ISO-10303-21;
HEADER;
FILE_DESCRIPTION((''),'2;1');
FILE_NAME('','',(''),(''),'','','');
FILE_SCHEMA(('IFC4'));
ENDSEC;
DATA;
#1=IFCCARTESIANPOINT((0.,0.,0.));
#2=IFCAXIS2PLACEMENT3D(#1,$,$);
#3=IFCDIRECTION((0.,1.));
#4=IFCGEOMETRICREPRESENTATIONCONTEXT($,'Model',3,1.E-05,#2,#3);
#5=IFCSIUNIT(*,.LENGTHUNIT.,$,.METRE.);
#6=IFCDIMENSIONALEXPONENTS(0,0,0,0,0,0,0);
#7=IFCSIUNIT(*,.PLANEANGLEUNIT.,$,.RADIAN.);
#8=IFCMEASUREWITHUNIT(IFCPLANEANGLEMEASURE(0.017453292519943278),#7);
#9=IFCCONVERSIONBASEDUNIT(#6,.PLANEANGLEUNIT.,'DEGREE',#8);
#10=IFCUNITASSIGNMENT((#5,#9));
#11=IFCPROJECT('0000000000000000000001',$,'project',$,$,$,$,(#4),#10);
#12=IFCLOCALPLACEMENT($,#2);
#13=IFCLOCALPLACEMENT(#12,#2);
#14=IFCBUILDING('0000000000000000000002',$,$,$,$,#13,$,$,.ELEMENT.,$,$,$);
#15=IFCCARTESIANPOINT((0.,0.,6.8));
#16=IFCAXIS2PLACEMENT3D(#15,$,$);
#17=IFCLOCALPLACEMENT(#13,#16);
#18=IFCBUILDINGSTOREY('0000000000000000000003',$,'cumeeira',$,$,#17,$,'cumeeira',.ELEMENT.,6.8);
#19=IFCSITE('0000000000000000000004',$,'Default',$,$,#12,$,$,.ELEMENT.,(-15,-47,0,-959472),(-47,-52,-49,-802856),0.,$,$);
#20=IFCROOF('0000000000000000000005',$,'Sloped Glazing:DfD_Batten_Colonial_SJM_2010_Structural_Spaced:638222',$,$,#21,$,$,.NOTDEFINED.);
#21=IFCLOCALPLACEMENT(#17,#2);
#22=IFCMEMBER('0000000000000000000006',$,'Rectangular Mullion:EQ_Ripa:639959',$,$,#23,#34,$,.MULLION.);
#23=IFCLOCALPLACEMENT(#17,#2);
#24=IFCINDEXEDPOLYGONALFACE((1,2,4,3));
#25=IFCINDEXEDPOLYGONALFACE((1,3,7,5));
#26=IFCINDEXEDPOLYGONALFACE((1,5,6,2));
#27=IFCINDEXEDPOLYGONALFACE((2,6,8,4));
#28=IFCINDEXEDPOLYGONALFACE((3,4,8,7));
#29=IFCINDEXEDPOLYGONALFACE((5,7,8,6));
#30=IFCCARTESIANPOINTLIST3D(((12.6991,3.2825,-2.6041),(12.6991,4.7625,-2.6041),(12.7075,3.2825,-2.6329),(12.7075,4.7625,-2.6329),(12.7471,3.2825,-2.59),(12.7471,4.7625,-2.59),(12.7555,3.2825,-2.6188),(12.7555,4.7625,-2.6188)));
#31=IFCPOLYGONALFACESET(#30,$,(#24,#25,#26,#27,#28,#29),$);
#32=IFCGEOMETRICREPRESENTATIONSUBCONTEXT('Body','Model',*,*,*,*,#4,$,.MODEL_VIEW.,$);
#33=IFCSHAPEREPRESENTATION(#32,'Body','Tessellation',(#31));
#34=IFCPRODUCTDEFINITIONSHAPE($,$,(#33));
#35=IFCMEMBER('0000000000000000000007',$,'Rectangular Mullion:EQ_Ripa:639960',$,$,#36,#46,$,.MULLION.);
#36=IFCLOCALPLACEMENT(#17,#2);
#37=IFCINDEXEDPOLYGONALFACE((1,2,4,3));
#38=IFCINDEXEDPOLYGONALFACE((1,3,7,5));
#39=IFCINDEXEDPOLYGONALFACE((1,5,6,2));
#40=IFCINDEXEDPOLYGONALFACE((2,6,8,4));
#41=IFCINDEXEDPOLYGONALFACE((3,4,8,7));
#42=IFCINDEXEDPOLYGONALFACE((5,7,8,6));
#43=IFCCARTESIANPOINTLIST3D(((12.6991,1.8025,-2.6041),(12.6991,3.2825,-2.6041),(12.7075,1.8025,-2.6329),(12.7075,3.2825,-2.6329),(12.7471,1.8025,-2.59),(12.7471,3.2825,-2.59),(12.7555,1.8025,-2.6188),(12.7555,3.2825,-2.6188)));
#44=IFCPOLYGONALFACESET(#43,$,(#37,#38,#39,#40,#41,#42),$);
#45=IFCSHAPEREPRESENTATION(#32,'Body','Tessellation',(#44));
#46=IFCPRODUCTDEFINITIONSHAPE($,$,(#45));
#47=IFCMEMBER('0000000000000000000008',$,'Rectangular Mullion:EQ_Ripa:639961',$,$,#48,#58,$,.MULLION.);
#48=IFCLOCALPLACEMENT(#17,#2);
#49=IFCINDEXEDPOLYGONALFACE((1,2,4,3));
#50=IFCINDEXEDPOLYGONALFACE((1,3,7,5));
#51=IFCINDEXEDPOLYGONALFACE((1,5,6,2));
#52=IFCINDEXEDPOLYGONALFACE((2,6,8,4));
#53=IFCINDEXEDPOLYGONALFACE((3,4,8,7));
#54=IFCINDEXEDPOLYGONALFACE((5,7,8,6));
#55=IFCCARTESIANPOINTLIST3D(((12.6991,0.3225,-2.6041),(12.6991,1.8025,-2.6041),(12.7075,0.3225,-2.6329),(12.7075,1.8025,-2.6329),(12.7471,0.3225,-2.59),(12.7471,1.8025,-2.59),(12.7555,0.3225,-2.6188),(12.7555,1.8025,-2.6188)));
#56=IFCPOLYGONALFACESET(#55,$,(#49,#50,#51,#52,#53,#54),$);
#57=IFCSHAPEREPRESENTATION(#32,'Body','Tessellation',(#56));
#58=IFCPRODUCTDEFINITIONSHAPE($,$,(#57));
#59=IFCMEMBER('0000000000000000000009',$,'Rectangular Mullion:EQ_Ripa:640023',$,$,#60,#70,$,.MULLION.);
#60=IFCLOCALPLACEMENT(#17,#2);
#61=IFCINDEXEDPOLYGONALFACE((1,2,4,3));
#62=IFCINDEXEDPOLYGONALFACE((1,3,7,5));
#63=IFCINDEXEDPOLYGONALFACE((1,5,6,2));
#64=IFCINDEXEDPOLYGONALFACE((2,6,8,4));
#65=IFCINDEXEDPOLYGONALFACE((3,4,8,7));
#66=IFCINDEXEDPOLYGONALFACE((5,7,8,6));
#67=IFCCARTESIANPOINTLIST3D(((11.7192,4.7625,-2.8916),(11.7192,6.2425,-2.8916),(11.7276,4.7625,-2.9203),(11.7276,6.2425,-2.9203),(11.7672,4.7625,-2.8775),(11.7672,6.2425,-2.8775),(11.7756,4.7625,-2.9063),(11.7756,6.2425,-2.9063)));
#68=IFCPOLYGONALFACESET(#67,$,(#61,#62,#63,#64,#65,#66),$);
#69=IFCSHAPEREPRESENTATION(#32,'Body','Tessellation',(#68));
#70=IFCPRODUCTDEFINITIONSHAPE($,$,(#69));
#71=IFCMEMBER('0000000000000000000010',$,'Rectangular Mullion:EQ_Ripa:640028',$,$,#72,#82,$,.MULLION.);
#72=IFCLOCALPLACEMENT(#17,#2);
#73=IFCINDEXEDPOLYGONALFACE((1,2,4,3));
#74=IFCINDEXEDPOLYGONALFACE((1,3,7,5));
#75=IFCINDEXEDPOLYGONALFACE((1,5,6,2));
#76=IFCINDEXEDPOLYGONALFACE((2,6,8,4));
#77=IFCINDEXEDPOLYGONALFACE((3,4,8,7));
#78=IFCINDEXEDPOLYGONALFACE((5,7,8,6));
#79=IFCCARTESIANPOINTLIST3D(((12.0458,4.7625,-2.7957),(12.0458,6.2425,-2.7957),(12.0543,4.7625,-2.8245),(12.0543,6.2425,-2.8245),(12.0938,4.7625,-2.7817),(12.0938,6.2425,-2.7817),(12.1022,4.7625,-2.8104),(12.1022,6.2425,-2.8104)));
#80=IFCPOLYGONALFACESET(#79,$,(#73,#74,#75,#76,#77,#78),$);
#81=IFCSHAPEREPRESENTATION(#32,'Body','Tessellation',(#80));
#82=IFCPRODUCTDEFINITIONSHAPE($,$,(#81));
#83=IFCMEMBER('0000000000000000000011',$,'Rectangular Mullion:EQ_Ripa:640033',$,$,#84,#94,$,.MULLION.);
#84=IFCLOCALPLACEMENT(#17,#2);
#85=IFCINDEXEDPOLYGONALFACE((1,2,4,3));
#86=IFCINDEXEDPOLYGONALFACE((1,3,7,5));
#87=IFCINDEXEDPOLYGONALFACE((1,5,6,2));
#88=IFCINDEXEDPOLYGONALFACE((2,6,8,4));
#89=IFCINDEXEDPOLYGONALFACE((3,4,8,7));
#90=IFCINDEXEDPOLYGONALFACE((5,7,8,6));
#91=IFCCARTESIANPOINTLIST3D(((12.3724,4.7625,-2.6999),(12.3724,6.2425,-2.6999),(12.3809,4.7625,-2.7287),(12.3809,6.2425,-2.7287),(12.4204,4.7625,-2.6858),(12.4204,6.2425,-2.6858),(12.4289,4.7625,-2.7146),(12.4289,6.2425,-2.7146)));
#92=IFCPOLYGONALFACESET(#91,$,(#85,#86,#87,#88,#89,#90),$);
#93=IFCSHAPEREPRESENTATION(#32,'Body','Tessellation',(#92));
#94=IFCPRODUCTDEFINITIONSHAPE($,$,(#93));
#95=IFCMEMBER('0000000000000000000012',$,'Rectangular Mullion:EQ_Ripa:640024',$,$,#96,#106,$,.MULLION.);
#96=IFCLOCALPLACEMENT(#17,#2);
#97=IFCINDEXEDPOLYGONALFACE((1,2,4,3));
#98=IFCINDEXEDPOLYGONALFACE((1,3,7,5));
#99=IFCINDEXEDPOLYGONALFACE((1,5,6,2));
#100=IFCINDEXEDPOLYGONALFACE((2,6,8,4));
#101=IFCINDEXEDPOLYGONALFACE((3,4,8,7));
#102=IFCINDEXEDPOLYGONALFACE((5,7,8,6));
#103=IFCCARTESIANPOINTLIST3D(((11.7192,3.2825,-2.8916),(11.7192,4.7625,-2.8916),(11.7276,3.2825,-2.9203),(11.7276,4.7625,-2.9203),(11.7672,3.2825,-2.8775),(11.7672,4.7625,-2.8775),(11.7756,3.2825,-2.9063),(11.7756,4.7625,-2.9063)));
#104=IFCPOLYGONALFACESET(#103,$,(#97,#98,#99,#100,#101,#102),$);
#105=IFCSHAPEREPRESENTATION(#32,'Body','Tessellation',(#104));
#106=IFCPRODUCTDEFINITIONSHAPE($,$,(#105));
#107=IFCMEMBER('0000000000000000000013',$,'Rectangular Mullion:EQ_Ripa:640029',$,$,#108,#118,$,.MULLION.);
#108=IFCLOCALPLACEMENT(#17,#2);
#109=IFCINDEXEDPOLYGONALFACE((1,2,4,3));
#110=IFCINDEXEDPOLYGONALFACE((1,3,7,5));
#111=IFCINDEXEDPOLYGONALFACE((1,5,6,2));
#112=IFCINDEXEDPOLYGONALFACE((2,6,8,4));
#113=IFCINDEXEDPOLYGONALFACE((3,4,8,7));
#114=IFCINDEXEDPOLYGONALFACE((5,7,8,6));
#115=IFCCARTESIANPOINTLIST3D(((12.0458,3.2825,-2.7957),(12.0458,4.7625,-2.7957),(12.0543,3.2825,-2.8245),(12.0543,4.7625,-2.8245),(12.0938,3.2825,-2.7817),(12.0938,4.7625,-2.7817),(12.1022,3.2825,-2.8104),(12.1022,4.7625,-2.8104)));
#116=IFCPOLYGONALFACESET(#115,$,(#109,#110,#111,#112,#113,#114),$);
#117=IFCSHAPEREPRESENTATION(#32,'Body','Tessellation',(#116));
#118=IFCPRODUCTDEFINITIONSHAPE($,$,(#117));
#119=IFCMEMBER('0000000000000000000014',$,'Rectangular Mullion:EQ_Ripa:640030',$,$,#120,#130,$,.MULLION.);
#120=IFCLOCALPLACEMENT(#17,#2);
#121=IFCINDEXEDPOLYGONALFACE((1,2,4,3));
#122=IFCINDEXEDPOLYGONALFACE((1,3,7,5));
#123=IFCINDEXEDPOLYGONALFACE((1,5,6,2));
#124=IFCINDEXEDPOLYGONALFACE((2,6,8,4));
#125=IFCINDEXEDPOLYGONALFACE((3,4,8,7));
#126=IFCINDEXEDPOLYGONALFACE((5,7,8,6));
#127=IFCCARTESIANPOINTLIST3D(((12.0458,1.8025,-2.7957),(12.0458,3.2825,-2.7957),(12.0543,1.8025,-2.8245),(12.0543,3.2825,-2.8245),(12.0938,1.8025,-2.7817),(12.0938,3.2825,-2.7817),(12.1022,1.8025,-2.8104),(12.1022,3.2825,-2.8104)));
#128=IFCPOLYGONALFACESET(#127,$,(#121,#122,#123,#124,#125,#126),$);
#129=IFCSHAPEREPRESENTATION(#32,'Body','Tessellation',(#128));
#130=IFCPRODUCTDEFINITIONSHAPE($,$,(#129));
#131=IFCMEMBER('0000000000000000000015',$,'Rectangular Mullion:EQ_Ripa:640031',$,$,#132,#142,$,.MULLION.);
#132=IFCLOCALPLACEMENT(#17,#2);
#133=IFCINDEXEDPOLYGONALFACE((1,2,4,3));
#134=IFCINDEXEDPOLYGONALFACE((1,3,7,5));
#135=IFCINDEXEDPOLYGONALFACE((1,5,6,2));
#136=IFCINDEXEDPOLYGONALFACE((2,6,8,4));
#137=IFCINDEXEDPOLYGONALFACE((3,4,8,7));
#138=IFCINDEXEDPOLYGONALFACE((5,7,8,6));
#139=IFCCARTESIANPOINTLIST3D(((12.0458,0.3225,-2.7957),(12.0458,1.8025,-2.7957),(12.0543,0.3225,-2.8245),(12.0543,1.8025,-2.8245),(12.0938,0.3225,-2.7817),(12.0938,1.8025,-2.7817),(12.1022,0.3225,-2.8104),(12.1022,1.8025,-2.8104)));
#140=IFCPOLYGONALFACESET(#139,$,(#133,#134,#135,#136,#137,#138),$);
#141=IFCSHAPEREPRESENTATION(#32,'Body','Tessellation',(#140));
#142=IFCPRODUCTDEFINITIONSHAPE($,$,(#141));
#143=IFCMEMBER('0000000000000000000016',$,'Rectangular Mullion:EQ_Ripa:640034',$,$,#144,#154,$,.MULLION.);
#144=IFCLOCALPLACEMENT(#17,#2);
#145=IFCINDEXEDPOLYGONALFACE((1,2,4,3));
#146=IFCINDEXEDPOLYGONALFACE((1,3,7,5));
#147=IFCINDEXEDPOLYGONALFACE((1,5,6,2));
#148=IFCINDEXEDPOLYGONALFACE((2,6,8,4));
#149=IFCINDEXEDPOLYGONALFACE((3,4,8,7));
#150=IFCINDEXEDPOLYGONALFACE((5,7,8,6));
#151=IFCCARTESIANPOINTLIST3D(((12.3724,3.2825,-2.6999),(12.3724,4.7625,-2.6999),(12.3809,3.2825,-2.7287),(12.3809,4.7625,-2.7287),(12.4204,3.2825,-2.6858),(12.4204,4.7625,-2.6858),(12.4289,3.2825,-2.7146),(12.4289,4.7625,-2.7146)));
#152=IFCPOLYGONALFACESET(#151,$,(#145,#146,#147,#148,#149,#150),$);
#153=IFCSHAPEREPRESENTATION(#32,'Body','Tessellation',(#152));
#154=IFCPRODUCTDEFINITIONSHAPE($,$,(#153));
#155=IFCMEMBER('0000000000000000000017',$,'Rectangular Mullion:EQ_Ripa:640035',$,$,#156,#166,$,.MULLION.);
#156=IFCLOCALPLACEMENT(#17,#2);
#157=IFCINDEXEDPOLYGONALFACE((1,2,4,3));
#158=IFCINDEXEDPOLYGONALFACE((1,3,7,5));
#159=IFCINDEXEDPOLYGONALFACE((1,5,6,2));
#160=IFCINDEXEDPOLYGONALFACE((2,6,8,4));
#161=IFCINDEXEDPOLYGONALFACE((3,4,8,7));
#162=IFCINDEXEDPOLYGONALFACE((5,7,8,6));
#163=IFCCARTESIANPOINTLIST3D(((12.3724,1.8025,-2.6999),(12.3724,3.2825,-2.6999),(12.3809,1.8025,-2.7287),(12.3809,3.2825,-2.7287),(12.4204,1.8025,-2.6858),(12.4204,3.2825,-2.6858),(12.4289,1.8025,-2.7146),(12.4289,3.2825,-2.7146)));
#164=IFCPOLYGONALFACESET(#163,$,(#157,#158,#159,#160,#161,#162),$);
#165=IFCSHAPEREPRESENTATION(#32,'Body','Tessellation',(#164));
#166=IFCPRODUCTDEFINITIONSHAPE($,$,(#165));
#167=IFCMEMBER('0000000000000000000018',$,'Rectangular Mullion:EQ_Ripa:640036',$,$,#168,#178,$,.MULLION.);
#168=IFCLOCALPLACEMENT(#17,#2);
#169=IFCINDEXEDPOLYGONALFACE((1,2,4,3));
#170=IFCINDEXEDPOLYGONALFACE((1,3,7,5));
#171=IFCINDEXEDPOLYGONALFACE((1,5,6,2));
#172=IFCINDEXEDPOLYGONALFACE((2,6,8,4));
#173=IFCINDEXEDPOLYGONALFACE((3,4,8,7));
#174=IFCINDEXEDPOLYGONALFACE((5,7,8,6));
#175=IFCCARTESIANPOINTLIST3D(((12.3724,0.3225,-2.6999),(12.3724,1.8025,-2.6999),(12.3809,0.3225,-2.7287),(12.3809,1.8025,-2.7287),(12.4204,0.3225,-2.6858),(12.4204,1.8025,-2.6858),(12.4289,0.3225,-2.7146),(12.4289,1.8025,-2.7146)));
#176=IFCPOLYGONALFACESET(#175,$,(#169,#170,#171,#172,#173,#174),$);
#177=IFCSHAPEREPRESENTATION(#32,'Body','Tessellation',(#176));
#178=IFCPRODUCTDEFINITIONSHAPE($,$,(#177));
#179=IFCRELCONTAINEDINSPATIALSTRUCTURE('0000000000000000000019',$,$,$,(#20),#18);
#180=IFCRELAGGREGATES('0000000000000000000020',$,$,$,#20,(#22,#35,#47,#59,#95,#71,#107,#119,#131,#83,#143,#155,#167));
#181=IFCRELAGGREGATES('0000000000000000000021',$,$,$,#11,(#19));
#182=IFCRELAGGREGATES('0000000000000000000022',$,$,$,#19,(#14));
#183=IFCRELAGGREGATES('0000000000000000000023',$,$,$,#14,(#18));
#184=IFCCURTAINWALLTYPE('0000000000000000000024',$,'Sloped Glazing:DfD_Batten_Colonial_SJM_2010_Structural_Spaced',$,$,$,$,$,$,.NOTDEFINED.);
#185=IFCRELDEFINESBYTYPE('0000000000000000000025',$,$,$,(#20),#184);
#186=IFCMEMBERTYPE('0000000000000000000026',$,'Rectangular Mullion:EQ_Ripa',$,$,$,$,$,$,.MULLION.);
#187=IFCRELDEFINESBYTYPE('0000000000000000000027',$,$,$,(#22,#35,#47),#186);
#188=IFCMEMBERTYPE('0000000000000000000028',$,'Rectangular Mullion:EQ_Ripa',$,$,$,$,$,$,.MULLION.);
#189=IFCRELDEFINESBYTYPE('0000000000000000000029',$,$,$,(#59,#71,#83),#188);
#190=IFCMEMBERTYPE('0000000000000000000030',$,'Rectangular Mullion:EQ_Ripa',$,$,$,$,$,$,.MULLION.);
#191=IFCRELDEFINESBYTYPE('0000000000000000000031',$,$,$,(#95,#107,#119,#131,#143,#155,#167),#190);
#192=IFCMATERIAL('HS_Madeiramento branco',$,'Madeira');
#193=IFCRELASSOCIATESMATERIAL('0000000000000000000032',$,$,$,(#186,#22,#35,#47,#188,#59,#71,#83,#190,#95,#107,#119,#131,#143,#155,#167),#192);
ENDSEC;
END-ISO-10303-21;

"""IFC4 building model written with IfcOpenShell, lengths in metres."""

from ifc_helpers import new_model, entity, si_unit, converted_unit, direction, frame, origin, place, context, subcontext, project, spatial, indexed_curve, outline, extrude, source, transform, mapped, material, type_object, type_shapes, element, aggregate, save


model = new_model("IFC4")

# Units and contexts
model_context = context("Model", 3, precision=1e-05, world=origin(), true_north=direction((0.0, 1.0)))
body_context = subcontext(model_context, "Body", "Model", "MODEL_VIEW")
ifc_project = project(units=[si_unit("LENGTHUNIT", "METRE"), converted_unit("PLANEANGLEUNIT", "DEGREE", entity("IfcPlaneAngleMeasure", 0.017453292519943278), si_unit("PLANEANGLEUNIT", "RADIAN"), dimensions=[0, 0, 0, 0, 0, 0, 0])], contexts=[model_context])

# Site, building, storey
site_placement = place(None, origin())
site = spatial("IfcSite", under=ifc_project, at=site_placement, Name="Default", CompositionType="ELEMENT", RefLatitude=(-15, -47, 0, -959472), RefLongitude=(-47, -52, -49, -802856), RefElevation=0.0)
building_placement = place(site_placement, origin())
building = spatial("IfcBuilding", under=site, at=building_placement, CompositionType="ELEMENT")
storey_placement = place(building_placement, frame((0.0, 0.0, 6.8)))
storey = spatial("IfcBuildingStorey", under=building, at=storey_placement, Name="cumeeira", LongName="cumeeira", CompositionType="ELEMENT", Elevation=6.8)

# Roof, members
curtain_wall_type = type_object("IfcCurtainWallType", Name="Sloped Glazing:DfD_Batten_Colonial_SJM_2010_Structural_Spaced", PredefinedType="NOTDEFINED")
ifc_material = material(Name="HS_Madeiramento branco", Category="Madeira")
roof_1_placement = place(storey_placement, frame((0.0, 0.0, -6.8)))
roof_1 = element("IfcRoof", 1, at=roof_1_placement, inside=storey, type_object=curtain_wall_type, Name="Sloped Glazing:DfD_Batten_Colonial_SJM_2010_Structural_Spaced:638222", PredefinedType="NOTDEFINED")
member_type_1 = type_object("IfcMemberType", Name="Rectangular Mullion:EQ_Ripa", PredefinedType="MULLION", material=ifc_material)
shared_shape_1 = source(origin(), body_context, "Body", "SweptSolid", [
    extrude(outline(indexed_curve([(-0.025, -0.015), (0.025, -0.015), (0.025, 0.015), (-0.025, 0.015), (-0.025, -0.015)], self_intersect=False)), frame((-0.025, 0.0, -1.48), z_axis=(0.0, 0.0, 1.0), x_axis=(-1.0, 0.0, 0.0)), (0.0, 0.0, 1.0), 1.48),
])
type_shapes(member_type_1, [shared_shape_1])
member_1_placement = place(roof_1_placement, frame((12.7513, 4.7625, 4.1956), z_axis=(0.0, 1.0, 0.0), x_axis=(0.95956, 0.0, 0.281504)))
member_1 = element("IfcMember", 2, at=member_1_placement, type_object=member_type_1, material=ifc_material, Name="Rectangular Mullion:EQ_Ripa:639959", PredefinedType="MULLION", context=body_context, shape_type="MappedRepresentation", body=[
    mapped(shared_shape_1, transform((0.0, 0.0, 0.0), scale=1.0)),
])
member_2_placement = place(roof_1_placement, frame((12.7513, 3.2825, 4.1956), z_axis=(0.0, 1.0, 0.0), x_axis=(0.95956, 0.0, 0.281504)))
member_2 = element("IfcMember", 3, at=member_2_placement, type_object=member_type_1, material=ifc_material, Name="Rectangular Mullion:EQ_Ripa:639960", PredefinedType="MULLION", context=body_context, shape_type="MappedRepresentation", body=[
    mapped(shared_shape_1, transform((0.0, 0.0, 0.0), scale=1.0)),
])
member_3_placement = place(roof_1_placement, frame((12.7513, 1.8025, 4.1956), z_axis=(0.0, 1.0, 0.0), x_axis=(0.95956, 0.0, 0.281504)))
member_3 = element("IfcMember", 4, at=member_3_placement, type_object=member_type_1, material=ifc_material, Name="Rectangular Mullion:EQ_Ripa:639961", PredefinedType="MULLION", context=body_context, shape_type="MappedRepresentation", body=[
    mapped(shared_shape_1, transform((0.0, 0.0, 0.0), scale=1.0)),
])
member_type_2 = type_object("IfcMemberType", Name="Rectangular Mullion:EQ_Ripa", PredefinedType="MULLION", material=ifc_material)
shared_shape_2 = source(origin(), body_context, "Body", "SweptSolid", [
    extrude(outline(indexed_curve([(-0.025, -0.015), (0.025, -0.015), (0.025, 0.015), (-0.025, 0.015), (-0.025, -0.015)], self_intersect=False)), frame((0.0, 0.0, -1.48), z_axis=(0.0, 0.0, 1.0), x_axis=(-1.0, 0.0, 0.0)), (0.0, 0.0, 1.0), 1.48),
])
type_shapes(member_type_2, [shared_shape_2])
member_4_placement = place(roof_1_placement, frame((11.7474, 6.2425, 3.9011), z_axis=(0.0, 1.0, 0.0), x_axis=(0.95956, 0.0, 0.281504)))
member_4 = element("IfcMember", 5, at=member_4_placement, type_object=member_type_2, material=ifc_material, Name="Rectangular Mullion:EQ_Ripa:640023", PredefinedType="MULLION", context=body_context, shape_type="MappedRepresentation", body=[
    mapped(shared_shape_2, transform((0.0, 0.0, 0.0), scale=1.0)),
])
member_5_placement = place(roof_1_placement, frame((12.074, 6.2425, 3.9969), z_axis=(0.0, 1.0, 0.0), x_axis=(0.95956, 0.0, 0.281504)))
member_5 = element("IfcMember", 6, at=member_5_placement, type_object=member_type_2, material=ifc_material, Name="Rectangular Mullion:EQ_Ripa:640028", PredefinedType="MULLION", context=body_context, shape_type="MappedRepresentation", body=[
    mapped(shared_shape_2, transform((0.0, 0.0, 0.0), scale=1.0)),
])
member_6_placement = place(roof_1_placement, frame((12.4007, 6.2425, 4.0927), z_axis=(0.0, 1.0, 0.0), x_axis=(0.95956, 0.0, 0.281504)))
member_6 = element("IfcMember", 7, at=member_6_placement, type_object=member_type_2, material=ifc_material, Name="Rectangular Mullion:EQ_Ripa:640033", PredefinedType="MULLION", context=body_context, shape_type="MappedRepresentation", body=[
    mapped(shared_shape_2, transform((0.0, 0.0, 0.0), scale=1.0)),
])
member_type_3 = type_object("IfcMemberType", Name="Rectangular Mullion:EQ_Ripa", PredefinedType="MULLION", material=ifc_material)
shared_shape_3 = source(origin(), body_context, "Body", "SweptSolid", [
    extrude(outline(indexed_curve([(-0.025, -0.015), (0.025, -0.015), (0.025, 0.015), (-0.025, 0.015), (-0.025, -0.015)], self_intersect=False)), frame((0.0, 0.0, -1.48), z_axis=(0.0, 0.0, 1.0), x_axis=(-1.0, 0.0, 0.0)), (0.0, 0.0, 1.0), 1.48),
])
type_shapes(member_type_3, [shared_shape_3])
member_7_placement = place(roof_1_placement, frame((11.7474, 4.7625, 3.9011), z_axis=(0.0, 1.0, 0.0), x_axis=(0.95956, 0.0, 0.281504)))
member_7 = element("IfcMember", 8, at=member_7_placement, type_object=member_type_3, material=ifc_material, Name="Rectangular Mullion:EQ_Ripa:640024", PredefinedType="MULLION", context=body_context, shape_type="MappedRepresentation", body=[
    mapped(shared_shape_3, transform((0.0, 0.0, 0.0), scale=1.0)),
])
member_8_placement = place(roof_1_placement, frame((12.074, 4.7625, 3.9969), z_axis=(0.0, 1.0, 0.0), x_axis=(0.95956, 0.0, 0.281504)))
member_8 = element("IfcMember", 9, at=member_8_placement, type_object=member_type_3, material=ifc_material, Name="Rectangular Mullion:EQ_Ripa:640029", PredefinedType="MULLION", context=body_context, shape_type="MappedRepresentation", body=[
    mapped(shared_shape_3, transform((0.0, 0.0, 0.0), scale=1.0)),
])
member_9_placement = place(roof_1_placement, frame((12.074, 3.2825, 3.9969), z_axis=(0.0, 1.0, 0.0), x_axis=(0.95956, 0.0, 0.281504)))
member_9 = element("IfcMember", 10, at=member_9_placement, type_object=member_type_3, material=ifc_material, Name="Rectangular Mullion:EQ_Ripa:640030", PredefinedType="MULLION", context=body_context, shape_type="MappedRepresentation", body=[
    mapped(shared_shape_3, transform((0.0, 0.0, 0.0), scale=1.0)),
])
member_10_placement = place(roof_1_placement, frame((12.074, 1.8025, 3.9969), z_axis=(0.0, 1.0, 0.0), x_axis=(0.95956, 0.0, 0.281504)))
member_10 = element("IfcMember", 11, at=member_10_placement, type_object=member_type_3, material=ifc_material, Name="Rectangular Mullion:EQ_Ripa:640031", PredefinedType="MULLION", context=body_context, shape_type="MappedRepresentation", body=[
    mapped(shared_shape_3, transform((0.0, 0.0, 0.0), scale=1.0)),
])
member_11_placement = place(roof_1_placement, frame((12.4007, 4.7625, 4.0927), z_axis=(0.0, 1.0, 0.0), x_axis=(0.95956, 0.0, 0.281504)))
member_11 = element("IfcMember", 12, at=member_11_placement, type_object=member_type_3, material=ifc_material, Name="Rectangular Mullion:EQ_Ripa:640034", PredefinedType="MULLION", context=body_context, shape_type="MappedRepresentation", body=[
    mapped(shared_shape_3, transform((0.0, 0.0, 0.0), scale=1.0)),
])
member_12_placement = place(roof_1_placement, frame((12.4007, 3.2825, 4.0927), z_axis=(0.0, 1.0, 0.0), x_axis=(0.95956, 0.0, 0.281504)))
member_12 = element("IfcMember", 13, at=member_12_placement, type_object=member_type_3, material=ifc_material, Name="Rectangular Mullion:EQ_Ripa:640035", PredefinedType="MULLION", context=body_context, shape_type="MappedRepresentation", body=[
    mapped(shared_shape_3, transform((0.0, 0.0, 0.0), scale=1.0)),
])
member_13_placement = place(roof_1_placement, frame((12.4007, 1.8025, 4.0927), z_axis=(0.0, 1.0, 0.0), x_axis=(0.95956, 0.0, 0.281504)))
member_13 = element("IfcMember", 14, at=member_13_placement, type_object=member_type_3, material=ifc_material, Name="Rectangular Mullion:EQ_Ripa:640036", PredefinedType="MULLION", context=body_context, shape_type="MappedRepresentation", body=[
    mapped(shared_shape_3, transform((0.0, 0.0, 0.0), scale=1.0)),
])
aggregate(roof_1, [member_1, member_2, member_3, member_4, member_7, member_5, member_8, member_9, member_10, member_6, member_11, member_12, member_13])

save(model, "model.ifc")
